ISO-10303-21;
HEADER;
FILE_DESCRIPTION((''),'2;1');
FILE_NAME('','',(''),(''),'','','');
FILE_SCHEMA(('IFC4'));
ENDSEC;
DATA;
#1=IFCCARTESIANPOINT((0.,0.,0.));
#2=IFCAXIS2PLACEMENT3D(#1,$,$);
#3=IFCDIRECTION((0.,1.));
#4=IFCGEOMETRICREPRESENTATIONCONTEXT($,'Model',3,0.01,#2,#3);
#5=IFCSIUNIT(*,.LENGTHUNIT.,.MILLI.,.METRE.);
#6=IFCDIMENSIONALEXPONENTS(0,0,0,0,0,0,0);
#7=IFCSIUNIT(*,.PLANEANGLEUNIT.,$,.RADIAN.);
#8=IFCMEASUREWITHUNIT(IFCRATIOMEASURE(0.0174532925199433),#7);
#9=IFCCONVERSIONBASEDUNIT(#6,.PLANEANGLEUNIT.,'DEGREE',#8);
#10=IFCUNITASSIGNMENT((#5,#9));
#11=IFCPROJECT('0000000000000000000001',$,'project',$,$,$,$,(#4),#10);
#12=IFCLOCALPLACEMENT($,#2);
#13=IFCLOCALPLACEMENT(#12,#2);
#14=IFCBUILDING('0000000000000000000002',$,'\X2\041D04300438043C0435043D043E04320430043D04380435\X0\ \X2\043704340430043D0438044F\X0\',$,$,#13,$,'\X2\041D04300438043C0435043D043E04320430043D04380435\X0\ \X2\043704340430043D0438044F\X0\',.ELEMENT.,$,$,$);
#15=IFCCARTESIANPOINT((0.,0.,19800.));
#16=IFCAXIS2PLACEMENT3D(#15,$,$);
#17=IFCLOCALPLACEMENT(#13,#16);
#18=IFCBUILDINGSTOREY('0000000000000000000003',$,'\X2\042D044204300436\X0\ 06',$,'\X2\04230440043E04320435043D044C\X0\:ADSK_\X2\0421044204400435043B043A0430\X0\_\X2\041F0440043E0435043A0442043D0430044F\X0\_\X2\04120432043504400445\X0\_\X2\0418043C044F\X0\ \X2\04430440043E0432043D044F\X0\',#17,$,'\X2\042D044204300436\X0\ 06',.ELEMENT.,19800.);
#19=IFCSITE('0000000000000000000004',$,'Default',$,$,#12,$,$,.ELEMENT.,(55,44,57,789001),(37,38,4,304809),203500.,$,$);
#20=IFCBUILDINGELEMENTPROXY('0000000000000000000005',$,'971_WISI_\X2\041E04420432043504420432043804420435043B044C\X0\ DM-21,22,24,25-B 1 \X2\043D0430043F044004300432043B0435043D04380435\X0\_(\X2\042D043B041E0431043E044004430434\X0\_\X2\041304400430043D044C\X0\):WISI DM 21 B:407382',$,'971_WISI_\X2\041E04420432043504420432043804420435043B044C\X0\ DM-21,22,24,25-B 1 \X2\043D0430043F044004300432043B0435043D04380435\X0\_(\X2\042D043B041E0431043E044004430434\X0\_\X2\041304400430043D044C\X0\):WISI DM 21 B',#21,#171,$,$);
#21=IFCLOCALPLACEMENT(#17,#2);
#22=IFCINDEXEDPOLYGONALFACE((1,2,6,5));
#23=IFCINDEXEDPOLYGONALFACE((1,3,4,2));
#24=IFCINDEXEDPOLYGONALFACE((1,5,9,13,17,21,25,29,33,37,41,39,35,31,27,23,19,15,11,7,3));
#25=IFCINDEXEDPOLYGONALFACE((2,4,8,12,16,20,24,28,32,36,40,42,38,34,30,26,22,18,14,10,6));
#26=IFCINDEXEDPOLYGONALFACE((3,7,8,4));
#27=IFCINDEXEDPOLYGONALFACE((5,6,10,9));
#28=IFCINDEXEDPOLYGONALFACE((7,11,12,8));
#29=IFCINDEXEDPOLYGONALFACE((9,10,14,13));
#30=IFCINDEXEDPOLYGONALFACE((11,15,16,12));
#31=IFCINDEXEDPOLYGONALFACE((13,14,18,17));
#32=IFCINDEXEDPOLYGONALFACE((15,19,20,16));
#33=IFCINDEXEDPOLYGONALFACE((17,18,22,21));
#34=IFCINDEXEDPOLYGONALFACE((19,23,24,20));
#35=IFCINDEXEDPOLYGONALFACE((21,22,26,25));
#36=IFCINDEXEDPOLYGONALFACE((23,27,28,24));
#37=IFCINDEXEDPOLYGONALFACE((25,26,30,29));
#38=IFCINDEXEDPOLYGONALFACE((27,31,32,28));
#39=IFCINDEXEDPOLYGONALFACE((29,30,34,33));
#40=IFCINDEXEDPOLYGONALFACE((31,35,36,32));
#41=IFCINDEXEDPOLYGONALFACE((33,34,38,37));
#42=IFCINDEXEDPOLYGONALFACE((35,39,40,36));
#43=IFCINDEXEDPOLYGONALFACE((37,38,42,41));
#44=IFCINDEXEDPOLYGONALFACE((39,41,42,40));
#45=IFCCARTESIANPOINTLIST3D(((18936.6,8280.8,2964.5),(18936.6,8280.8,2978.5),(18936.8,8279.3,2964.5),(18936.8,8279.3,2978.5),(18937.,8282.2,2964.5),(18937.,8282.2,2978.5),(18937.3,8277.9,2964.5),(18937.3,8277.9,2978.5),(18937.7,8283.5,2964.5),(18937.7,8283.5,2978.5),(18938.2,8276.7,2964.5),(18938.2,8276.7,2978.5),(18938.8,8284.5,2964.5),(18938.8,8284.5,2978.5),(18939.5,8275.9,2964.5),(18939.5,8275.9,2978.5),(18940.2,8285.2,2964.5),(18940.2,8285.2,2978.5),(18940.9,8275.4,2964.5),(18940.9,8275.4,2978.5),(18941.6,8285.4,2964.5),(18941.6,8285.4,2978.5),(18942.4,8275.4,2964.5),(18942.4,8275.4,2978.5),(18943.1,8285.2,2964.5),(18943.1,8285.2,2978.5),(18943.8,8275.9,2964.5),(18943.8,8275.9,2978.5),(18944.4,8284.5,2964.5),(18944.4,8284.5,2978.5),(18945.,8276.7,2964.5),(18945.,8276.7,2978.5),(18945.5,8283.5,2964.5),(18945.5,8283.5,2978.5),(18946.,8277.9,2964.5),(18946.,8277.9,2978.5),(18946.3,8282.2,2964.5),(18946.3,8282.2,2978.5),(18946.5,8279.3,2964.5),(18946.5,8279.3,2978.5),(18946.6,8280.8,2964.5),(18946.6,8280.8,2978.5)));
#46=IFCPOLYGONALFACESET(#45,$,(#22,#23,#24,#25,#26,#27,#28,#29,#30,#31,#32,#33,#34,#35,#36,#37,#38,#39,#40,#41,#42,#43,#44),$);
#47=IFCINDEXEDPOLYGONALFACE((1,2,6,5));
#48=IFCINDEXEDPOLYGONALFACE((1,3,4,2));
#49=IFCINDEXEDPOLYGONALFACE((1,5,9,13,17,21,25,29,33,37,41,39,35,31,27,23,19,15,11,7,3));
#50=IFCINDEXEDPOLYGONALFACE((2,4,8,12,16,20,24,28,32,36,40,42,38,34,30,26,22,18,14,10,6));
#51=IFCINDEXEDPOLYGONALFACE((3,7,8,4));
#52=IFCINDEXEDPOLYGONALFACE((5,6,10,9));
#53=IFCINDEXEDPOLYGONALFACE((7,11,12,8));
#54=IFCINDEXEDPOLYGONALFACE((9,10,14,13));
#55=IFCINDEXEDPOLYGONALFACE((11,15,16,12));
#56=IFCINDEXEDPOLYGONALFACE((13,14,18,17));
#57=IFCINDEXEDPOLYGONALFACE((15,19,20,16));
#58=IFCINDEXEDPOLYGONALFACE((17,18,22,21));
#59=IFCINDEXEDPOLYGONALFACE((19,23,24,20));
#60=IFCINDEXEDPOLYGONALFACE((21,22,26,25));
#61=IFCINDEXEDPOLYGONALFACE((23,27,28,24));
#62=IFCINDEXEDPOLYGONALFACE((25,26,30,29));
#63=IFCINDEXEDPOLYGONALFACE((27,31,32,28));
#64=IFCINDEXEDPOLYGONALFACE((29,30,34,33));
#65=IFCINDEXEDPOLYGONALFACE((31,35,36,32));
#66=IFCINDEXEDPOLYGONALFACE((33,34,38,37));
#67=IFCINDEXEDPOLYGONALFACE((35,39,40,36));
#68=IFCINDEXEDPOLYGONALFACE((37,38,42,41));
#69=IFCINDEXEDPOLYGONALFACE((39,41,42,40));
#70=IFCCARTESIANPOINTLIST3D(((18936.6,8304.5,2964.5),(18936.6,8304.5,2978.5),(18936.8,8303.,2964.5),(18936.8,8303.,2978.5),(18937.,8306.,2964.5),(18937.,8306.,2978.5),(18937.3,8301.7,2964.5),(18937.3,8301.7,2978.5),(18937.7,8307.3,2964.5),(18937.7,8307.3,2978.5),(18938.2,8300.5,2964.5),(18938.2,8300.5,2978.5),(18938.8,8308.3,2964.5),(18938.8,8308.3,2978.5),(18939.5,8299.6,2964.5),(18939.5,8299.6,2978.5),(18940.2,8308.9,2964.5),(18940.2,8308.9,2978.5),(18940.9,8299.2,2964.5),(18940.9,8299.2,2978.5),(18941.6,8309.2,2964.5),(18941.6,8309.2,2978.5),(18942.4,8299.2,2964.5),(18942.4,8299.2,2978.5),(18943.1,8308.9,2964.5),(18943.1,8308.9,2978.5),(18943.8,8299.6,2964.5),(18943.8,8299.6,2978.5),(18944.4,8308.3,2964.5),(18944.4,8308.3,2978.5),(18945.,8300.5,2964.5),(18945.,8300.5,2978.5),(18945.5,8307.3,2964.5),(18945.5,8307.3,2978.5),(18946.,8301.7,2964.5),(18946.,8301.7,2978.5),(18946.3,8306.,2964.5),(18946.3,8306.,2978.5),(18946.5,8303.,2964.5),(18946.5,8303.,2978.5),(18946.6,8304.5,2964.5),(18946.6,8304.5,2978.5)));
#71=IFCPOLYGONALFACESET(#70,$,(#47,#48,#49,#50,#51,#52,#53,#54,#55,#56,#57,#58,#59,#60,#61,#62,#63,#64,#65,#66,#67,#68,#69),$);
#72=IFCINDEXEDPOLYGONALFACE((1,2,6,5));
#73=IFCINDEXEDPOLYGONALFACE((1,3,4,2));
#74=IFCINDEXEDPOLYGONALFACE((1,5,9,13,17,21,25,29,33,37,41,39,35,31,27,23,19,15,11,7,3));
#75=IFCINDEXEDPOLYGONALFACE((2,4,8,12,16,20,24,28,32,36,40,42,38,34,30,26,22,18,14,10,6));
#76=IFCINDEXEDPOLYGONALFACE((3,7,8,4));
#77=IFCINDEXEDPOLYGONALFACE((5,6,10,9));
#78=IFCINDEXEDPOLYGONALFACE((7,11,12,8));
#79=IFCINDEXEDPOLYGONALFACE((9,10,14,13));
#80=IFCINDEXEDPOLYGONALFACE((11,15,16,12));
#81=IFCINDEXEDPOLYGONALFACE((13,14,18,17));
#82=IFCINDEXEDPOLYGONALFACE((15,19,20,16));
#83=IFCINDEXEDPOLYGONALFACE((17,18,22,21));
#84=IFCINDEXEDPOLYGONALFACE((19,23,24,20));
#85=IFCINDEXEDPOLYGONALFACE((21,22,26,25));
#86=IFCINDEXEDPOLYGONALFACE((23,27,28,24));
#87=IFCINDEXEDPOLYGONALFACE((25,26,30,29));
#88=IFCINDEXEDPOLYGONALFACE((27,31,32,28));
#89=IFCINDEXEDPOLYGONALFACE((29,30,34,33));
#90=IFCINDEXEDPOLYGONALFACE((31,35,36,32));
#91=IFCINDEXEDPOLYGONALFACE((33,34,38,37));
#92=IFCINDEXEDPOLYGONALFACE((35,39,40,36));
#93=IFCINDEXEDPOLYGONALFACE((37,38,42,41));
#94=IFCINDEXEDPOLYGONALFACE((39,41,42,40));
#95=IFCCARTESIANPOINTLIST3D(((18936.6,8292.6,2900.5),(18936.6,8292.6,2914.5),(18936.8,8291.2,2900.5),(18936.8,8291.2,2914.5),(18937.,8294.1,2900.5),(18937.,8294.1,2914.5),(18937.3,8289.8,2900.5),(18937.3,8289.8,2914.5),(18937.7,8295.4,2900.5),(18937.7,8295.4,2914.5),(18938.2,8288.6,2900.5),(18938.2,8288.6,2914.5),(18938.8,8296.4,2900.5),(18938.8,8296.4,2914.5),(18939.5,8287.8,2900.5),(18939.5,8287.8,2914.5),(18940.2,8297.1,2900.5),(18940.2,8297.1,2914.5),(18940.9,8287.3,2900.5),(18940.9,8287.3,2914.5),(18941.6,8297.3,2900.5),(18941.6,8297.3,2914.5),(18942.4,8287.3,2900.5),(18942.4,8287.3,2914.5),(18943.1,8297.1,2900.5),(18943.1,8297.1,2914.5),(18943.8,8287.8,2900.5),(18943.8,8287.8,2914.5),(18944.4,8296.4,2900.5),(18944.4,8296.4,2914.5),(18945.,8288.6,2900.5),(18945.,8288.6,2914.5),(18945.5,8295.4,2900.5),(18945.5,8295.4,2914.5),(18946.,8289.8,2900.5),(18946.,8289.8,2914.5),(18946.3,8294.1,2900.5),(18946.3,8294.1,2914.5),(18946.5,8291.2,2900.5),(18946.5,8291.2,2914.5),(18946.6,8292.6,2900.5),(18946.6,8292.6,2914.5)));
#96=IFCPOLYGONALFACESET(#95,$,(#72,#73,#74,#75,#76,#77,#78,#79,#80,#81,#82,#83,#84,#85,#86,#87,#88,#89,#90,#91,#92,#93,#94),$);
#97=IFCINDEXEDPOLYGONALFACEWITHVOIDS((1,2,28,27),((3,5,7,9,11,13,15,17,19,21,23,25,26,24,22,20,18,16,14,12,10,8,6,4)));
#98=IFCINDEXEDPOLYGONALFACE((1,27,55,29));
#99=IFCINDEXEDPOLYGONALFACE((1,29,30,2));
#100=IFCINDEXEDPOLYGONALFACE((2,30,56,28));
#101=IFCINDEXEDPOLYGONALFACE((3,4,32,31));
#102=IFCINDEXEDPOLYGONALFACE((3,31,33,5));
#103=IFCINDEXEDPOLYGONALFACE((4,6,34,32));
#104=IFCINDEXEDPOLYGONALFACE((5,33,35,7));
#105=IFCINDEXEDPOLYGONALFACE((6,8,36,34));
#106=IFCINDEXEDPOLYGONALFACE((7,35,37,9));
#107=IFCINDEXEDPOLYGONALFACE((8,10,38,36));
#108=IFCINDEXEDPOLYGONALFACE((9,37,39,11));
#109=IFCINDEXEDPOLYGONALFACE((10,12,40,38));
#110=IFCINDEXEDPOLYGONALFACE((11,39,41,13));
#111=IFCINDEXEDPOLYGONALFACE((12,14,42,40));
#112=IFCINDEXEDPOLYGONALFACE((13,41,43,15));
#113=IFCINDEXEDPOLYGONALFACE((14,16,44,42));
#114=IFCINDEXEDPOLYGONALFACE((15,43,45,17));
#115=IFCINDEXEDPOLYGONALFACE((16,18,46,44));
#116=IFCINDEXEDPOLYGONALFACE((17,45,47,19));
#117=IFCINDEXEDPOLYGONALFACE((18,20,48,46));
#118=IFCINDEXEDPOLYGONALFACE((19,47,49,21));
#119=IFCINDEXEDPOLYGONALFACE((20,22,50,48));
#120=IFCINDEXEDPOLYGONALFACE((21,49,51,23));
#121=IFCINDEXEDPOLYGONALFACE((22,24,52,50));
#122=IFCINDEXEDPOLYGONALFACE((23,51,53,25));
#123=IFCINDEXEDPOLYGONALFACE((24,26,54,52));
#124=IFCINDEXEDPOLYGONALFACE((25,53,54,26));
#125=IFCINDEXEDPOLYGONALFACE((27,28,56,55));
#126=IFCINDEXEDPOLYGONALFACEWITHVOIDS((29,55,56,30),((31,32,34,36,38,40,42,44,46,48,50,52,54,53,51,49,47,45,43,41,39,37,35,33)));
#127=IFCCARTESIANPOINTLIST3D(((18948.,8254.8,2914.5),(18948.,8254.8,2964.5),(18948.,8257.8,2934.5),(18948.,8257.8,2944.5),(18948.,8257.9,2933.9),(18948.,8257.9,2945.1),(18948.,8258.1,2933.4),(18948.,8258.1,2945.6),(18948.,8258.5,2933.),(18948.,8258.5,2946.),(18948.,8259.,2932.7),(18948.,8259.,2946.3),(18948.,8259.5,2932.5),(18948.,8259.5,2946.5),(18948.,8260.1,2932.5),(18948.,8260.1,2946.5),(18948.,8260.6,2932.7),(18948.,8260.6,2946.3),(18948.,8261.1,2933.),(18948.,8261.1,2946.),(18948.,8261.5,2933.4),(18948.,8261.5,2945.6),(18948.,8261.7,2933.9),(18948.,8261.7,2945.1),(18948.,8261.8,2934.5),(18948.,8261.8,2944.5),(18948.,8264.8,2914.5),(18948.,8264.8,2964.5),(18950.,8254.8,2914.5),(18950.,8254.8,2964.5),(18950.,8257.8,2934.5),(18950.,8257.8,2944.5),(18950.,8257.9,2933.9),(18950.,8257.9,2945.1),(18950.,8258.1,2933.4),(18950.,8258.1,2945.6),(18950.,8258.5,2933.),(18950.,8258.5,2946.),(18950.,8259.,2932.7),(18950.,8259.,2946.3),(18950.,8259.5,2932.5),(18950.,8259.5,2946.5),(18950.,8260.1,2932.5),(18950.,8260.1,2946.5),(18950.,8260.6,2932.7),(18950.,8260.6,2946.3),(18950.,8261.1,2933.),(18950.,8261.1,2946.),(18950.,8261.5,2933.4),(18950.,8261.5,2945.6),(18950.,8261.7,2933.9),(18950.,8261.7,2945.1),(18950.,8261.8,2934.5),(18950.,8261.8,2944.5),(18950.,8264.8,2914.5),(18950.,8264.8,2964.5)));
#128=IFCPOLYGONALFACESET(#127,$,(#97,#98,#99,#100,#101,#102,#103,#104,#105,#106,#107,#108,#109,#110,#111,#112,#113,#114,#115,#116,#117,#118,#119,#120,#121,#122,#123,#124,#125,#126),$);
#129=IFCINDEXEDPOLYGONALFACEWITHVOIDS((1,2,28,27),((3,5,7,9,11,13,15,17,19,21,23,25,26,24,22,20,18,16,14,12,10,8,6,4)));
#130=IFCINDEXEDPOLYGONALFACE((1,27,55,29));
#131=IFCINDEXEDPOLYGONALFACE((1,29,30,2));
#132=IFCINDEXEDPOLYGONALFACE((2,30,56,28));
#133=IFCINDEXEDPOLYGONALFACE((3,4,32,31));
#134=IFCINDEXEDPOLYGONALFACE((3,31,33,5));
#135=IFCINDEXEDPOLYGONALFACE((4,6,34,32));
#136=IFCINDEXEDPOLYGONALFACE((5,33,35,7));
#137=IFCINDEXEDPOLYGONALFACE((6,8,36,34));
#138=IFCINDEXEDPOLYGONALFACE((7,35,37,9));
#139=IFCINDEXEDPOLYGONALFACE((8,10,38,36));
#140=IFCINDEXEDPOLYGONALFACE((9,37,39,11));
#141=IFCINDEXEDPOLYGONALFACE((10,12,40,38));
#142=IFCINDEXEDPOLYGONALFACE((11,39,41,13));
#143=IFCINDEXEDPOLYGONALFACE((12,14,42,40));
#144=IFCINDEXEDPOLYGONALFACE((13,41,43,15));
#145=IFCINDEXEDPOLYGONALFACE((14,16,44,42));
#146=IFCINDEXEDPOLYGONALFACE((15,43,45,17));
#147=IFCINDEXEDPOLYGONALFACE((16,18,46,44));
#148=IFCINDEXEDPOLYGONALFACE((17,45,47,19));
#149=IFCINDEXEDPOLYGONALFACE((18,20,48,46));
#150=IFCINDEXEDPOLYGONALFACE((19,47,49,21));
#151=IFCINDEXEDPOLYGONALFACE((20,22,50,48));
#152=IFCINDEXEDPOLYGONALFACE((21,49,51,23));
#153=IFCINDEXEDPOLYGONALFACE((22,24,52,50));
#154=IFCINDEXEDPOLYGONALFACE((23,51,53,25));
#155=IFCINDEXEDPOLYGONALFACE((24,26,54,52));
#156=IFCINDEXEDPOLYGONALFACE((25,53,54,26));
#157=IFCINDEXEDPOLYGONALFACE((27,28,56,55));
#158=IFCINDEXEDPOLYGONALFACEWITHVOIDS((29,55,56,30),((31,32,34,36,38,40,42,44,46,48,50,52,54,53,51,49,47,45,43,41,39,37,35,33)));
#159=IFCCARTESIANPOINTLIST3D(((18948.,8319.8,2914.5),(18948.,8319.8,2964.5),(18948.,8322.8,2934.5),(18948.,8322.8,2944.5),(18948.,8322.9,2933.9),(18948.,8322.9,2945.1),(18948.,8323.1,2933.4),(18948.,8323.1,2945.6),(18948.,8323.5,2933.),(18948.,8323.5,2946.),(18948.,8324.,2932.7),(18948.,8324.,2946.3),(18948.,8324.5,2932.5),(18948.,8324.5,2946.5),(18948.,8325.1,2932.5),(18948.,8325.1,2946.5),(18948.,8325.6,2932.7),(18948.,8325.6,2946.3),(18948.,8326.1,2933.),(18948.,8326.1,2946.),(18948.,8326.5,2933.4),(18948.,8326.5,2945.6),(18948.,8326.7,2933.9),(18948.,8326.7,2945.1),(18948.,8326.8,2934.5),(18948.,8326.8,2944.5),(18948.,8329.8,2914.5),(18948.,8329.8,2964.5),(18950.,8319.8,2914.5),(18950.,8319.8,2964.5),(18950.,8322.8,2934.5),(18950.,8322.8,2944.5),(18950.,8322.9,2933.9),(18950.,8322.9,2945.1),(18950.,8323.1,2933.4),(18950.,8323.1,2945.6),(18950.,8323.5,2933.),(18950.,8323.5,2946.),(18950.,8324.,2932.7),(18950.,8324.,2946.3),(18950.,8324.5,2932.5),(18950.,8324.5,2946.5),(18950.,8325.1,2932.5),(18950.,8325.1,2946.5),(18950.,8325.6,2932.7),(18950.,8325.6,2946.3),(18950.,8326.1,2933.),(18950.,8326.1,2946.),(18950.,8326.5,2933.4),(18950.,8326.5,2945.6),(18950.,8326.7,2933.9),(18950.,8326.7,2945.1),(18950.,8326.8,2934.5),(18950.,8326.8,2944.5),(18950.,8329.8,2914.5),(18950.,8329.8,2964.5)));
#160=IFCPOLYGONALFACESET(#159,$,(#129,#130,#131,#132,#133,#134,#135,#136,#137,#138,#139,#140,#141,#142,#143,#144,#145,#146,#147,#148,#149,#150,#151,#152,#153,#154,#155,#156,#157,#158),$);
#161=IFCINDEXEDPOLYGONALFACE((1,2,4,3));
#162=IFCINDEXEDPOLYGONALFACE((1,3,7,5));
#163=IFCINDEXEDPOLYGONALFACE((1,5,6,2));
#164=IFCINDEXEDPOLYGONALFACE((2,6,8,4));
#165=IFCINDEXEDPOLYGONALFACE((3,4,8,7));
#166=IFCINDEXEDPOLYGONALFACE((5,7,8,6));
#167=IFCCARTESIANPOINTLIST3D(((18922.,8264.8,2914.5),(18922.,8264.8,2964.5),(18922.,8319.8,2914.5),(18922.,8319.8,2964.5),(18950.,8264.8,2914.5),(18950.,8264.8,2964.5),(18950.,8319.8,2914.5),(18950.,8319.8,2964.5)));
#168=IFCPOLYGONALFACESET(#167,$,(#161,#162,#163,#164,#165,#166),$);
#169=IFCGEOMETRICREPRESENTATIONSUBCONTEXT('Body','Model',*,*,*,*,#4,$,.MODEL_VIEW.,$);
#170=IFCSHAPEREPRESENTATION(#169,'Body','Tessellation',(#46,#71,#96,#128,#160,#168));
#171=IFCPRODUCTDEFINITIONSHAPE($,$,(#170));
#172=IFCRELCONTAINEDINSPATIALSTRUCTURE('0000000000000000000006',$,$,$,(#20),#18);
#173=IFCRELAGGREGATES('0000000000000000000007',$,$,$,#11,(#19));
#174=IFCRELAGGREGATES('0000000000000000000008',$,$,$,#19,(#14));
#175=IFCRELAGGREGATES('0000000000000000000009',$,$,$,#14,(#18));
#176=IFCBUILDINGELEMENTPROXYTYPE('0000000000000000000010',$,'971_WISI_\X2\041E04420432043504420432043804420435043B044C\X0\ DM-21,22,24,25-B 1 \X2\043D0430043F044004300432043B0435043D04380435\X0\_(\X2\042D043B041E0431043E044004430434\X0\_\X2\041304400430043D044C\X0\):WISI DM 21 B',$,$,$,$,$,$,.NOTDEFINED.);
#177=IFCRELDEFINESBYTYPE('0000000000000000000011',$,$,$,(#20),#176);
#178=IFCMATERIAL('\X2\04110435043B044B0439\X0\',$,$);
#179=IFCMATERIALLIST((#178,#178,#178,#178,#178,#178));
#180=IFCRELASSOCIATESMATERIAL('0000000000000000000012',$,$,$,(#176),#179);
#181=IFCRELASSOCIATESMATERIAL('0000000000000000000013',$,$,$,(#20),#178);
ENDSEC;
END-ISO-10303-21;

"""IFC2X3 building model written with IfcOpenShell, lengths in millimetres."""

from ifc_helpers import new_model, entity, si_unit, converted_unit, direction, frame, frame_2d, origin, place, context, subcontext, project, spatial, polyline, circle_curve, parameter, trimmed, segment, composite_curve, rectangle, circle, outline, extrude, source, transform, mapped, material, material_list, type_object, type_shapes, element, save


model = new_model("IFC2X3")

# Units and contexts
model_context = context("Model", 3, precision=0.01, world=origin(), true_north=direction((0.0, 1.0)))
body_context = subcontext(model_context, "Body", "Model", "MODEL_VIEW")
ifc_project = project(units=[si_unit("LENGTHUNIT", "METRE", prefix="MILLI"), converted_unit("PLANEANGLEUNIT", "DEGREE", entity("IfcRatioMeasure", 0.0174532925199433), si_unit("PLANEANGLEUNIT", "RADIAN"), dimensions=[0, 0, 0, 0, 0, 0, 0])], contexts=[model_context])

# Site, building, storey
site_placement = place(None, frame((0.0, 0.0, 0.0)))
site = spatial("IfcSite", under=ifc_project, at=site_placement, Name="Default", CompositionType="ELEMENT", RefLatitude=(55, 44, 57, 789001), RefLongitude=(37, 38, 4, 304809), RefElevation=203500.0)
building_placement = place(site_placement, origin())
building = spatial("IfcBuilding", under=site, at=building_placement, Name="Наименование здания", LongName="Наименование здания", CompositionType="ELEMENT")
storey_placement = place(building_placement, frame((0.0, 0.0, 19800.0)))
storey = spatial("IfcBuildingStorey", under=building, at=storey_placement, Name="Этаж 06", ObjectType="Уровень:ADSK_Стрелка_Проектная_Вверх_Имя уровня", LongName="Этаж 06", CompositionType="ELEMENT", Elevation=19800.0)

# Building element proxy
ifc_material_1 = material(Name="Белый")
ifc_material_list_1 = material_list([ifc_material_1, ifc_material_1, ifc_material_1, ifc_material_1, ifc_material_1, ifc_material_1])
building_element_proxy_type_1 = type_object("IfcBuildingElementProxyType", Name="971_WISI_Ответвитель DM-21,22,24,25-B 1 направление_(ЭлОборуд_Грань):WISI DM 21 B", PredefinedType="NOTDEFINED", material=ifc_material_list_1)
shared_shape_1 = source(origin(), body_context, "Body", "SweptSolid", [
    extrude(circle(Radius=5.0, at=frame_2d((0.0, 0.0), x_axis=(1.0, 0.0))), frame((11.9, 25.0, 8.4), z_axis=(0.0, 1.0, 0.0), x_axis=(-1.0, 0.0, 0.0)), (0.0, 0.0, 1.0), 14.0),
    extrude(circle(Radius=5.0, at=frame_2d((0.0, 0.0), x_axis=(1.0, 0.0))), frame((-11.8, 25.0, 8.4), z_axis=(0.0, 1.0, 0.0), x_axis=(-1.0, 0.0, 0.0)), (0.0, 0.0, 1.0), 14.0),
    extrude(circle(Radius=5.0, at=frame_2d((0.0, 0.0), x_axis=(1.0, 0.0))), frame((0.0, -39.0, 8.4), z_axis=(0.0, 1.0, 0.0), x_axis=(-1.0, 0.0, 0.0)), (0.0, 0.0, 1.0), 14.0),
    extrude(outline(polyline([(-5.0, -25.0), (5.0, -25.0), (5.0, 25.0), (-5.0, 25.0), (-5.0, -25.0)]), holes=[composite_curve([segment(polyline([(2.0, 5.0), (2.0, -5.0)]), True, "CONTINUOUS"), segment(trimmed(circle_curve(frame_2d((0.0, -5.0), x_axis=(-1.0, 0.0)), 2.0), [parameter(0.0)], [parameter(180.0)], True, "PARAMETER"), False, "CONTINUOUS"), segment(polyline([(-2.0, -5.0), (-2.0, 5.0)]), True, "CONTINUOUS"), segment(trimmed(circle_curve(frame_2d((0.0, 5.0), x_axis=(-1.0, 0.0)), 2.0), [parameter(180.0)], [parameter(0.0)], True, "PARAMETER"), False, "CONTINUOUS")], self_intersect=False)]), frame((32.5, 0.0, 0.0), z_axis=(0.0, 0.0, 1.0), x_axis=(-1.0, 0.0, 0.0)), (0.0, 0.0, 1.0), 2.0),
    extrude(outline(polyline([(-5.0, -25.0), (5.0, -25.0), (5.0, 25.0), (-5.0, 25.0), (-5.0, -25.0)]), holes=[composite_curve([segment(polyline([(-2.0, -5.0), (-2.0, 5.0)]), True, "CONTINUOUS"), segment(trimmed(circle_curve(frame_2d((0.0, 5.0), x_axis=(-1.0, 0.0)), 2.0), [parameter(180.0)], [parameter(0.0)], True, "PARAMETER"), False, "CONTINUOUS"), segment(polyline([(2.0, 5.0), (2.0, -5.0)]), True, "CONTINUOUS"), segment(trimmed(circle_curve(frame_2d((0.0, -5.0), x_axis=(-1.0, 0.0)), 2.0), [parameter(0.0)], [parameter(180.0)], True, "PARAMETER"), False, "CONTINUOUS")], self_intersect=False)]), frame((-32.5, 0.0, 0.0), z_axis=(0.0, 0.0, 1.0), x_axis=(-1.0, 0.0, 0.0)), (0.0, 0.0, 1.0), 2.0),
    extrude(rectangle(XDim=55.0, YDim=50.0, at=frame_2d((0.0, 0.0), x_axis=(1.0, 0.0))), frame((0.0, 0.0, 0.0), z_axis=(0.0, 0.0, 1.0), x_axis=(-1.0, 0.0, 0.0)), (0.0, 0.0, 1.0), 28.0),
])
type_shapes(building_element_proxy_type_1, [shared_shape_1])
for number, where, z_axis, x_axis, name in (
    (1, (18950.0, 8292.3, 2939.5), (-1.0, 0.0, 0.0), (0.0, -1.0, 0.0), "971_WISI_Ответвитель DM-21,22,24,25-B 1 направление_(ЭлОборуд_Грань):WISI DM 21 B:407382"),
):
    element("IfcBuildingElementProxy", number, at=place(storey_placement, frame(where, z_axis=z_axis, x_axis=x_axis)), inside=storey, type_object=building_element_proxy_type_1, material=ifc_material_1, Name=name, ObjectType="971_WISI_Ответвитель DM-21,22,24,25-B 1 направление_(ЭлОборуд_Грань):WISI DM 21 B", context=body_context, shape_type="MappedRepresentation", body=[
        mapped(shared_shape_1, transform((0.0, 0.0, 0.0), scale=1.0)),
    ])

save(model, "model.ifc")
